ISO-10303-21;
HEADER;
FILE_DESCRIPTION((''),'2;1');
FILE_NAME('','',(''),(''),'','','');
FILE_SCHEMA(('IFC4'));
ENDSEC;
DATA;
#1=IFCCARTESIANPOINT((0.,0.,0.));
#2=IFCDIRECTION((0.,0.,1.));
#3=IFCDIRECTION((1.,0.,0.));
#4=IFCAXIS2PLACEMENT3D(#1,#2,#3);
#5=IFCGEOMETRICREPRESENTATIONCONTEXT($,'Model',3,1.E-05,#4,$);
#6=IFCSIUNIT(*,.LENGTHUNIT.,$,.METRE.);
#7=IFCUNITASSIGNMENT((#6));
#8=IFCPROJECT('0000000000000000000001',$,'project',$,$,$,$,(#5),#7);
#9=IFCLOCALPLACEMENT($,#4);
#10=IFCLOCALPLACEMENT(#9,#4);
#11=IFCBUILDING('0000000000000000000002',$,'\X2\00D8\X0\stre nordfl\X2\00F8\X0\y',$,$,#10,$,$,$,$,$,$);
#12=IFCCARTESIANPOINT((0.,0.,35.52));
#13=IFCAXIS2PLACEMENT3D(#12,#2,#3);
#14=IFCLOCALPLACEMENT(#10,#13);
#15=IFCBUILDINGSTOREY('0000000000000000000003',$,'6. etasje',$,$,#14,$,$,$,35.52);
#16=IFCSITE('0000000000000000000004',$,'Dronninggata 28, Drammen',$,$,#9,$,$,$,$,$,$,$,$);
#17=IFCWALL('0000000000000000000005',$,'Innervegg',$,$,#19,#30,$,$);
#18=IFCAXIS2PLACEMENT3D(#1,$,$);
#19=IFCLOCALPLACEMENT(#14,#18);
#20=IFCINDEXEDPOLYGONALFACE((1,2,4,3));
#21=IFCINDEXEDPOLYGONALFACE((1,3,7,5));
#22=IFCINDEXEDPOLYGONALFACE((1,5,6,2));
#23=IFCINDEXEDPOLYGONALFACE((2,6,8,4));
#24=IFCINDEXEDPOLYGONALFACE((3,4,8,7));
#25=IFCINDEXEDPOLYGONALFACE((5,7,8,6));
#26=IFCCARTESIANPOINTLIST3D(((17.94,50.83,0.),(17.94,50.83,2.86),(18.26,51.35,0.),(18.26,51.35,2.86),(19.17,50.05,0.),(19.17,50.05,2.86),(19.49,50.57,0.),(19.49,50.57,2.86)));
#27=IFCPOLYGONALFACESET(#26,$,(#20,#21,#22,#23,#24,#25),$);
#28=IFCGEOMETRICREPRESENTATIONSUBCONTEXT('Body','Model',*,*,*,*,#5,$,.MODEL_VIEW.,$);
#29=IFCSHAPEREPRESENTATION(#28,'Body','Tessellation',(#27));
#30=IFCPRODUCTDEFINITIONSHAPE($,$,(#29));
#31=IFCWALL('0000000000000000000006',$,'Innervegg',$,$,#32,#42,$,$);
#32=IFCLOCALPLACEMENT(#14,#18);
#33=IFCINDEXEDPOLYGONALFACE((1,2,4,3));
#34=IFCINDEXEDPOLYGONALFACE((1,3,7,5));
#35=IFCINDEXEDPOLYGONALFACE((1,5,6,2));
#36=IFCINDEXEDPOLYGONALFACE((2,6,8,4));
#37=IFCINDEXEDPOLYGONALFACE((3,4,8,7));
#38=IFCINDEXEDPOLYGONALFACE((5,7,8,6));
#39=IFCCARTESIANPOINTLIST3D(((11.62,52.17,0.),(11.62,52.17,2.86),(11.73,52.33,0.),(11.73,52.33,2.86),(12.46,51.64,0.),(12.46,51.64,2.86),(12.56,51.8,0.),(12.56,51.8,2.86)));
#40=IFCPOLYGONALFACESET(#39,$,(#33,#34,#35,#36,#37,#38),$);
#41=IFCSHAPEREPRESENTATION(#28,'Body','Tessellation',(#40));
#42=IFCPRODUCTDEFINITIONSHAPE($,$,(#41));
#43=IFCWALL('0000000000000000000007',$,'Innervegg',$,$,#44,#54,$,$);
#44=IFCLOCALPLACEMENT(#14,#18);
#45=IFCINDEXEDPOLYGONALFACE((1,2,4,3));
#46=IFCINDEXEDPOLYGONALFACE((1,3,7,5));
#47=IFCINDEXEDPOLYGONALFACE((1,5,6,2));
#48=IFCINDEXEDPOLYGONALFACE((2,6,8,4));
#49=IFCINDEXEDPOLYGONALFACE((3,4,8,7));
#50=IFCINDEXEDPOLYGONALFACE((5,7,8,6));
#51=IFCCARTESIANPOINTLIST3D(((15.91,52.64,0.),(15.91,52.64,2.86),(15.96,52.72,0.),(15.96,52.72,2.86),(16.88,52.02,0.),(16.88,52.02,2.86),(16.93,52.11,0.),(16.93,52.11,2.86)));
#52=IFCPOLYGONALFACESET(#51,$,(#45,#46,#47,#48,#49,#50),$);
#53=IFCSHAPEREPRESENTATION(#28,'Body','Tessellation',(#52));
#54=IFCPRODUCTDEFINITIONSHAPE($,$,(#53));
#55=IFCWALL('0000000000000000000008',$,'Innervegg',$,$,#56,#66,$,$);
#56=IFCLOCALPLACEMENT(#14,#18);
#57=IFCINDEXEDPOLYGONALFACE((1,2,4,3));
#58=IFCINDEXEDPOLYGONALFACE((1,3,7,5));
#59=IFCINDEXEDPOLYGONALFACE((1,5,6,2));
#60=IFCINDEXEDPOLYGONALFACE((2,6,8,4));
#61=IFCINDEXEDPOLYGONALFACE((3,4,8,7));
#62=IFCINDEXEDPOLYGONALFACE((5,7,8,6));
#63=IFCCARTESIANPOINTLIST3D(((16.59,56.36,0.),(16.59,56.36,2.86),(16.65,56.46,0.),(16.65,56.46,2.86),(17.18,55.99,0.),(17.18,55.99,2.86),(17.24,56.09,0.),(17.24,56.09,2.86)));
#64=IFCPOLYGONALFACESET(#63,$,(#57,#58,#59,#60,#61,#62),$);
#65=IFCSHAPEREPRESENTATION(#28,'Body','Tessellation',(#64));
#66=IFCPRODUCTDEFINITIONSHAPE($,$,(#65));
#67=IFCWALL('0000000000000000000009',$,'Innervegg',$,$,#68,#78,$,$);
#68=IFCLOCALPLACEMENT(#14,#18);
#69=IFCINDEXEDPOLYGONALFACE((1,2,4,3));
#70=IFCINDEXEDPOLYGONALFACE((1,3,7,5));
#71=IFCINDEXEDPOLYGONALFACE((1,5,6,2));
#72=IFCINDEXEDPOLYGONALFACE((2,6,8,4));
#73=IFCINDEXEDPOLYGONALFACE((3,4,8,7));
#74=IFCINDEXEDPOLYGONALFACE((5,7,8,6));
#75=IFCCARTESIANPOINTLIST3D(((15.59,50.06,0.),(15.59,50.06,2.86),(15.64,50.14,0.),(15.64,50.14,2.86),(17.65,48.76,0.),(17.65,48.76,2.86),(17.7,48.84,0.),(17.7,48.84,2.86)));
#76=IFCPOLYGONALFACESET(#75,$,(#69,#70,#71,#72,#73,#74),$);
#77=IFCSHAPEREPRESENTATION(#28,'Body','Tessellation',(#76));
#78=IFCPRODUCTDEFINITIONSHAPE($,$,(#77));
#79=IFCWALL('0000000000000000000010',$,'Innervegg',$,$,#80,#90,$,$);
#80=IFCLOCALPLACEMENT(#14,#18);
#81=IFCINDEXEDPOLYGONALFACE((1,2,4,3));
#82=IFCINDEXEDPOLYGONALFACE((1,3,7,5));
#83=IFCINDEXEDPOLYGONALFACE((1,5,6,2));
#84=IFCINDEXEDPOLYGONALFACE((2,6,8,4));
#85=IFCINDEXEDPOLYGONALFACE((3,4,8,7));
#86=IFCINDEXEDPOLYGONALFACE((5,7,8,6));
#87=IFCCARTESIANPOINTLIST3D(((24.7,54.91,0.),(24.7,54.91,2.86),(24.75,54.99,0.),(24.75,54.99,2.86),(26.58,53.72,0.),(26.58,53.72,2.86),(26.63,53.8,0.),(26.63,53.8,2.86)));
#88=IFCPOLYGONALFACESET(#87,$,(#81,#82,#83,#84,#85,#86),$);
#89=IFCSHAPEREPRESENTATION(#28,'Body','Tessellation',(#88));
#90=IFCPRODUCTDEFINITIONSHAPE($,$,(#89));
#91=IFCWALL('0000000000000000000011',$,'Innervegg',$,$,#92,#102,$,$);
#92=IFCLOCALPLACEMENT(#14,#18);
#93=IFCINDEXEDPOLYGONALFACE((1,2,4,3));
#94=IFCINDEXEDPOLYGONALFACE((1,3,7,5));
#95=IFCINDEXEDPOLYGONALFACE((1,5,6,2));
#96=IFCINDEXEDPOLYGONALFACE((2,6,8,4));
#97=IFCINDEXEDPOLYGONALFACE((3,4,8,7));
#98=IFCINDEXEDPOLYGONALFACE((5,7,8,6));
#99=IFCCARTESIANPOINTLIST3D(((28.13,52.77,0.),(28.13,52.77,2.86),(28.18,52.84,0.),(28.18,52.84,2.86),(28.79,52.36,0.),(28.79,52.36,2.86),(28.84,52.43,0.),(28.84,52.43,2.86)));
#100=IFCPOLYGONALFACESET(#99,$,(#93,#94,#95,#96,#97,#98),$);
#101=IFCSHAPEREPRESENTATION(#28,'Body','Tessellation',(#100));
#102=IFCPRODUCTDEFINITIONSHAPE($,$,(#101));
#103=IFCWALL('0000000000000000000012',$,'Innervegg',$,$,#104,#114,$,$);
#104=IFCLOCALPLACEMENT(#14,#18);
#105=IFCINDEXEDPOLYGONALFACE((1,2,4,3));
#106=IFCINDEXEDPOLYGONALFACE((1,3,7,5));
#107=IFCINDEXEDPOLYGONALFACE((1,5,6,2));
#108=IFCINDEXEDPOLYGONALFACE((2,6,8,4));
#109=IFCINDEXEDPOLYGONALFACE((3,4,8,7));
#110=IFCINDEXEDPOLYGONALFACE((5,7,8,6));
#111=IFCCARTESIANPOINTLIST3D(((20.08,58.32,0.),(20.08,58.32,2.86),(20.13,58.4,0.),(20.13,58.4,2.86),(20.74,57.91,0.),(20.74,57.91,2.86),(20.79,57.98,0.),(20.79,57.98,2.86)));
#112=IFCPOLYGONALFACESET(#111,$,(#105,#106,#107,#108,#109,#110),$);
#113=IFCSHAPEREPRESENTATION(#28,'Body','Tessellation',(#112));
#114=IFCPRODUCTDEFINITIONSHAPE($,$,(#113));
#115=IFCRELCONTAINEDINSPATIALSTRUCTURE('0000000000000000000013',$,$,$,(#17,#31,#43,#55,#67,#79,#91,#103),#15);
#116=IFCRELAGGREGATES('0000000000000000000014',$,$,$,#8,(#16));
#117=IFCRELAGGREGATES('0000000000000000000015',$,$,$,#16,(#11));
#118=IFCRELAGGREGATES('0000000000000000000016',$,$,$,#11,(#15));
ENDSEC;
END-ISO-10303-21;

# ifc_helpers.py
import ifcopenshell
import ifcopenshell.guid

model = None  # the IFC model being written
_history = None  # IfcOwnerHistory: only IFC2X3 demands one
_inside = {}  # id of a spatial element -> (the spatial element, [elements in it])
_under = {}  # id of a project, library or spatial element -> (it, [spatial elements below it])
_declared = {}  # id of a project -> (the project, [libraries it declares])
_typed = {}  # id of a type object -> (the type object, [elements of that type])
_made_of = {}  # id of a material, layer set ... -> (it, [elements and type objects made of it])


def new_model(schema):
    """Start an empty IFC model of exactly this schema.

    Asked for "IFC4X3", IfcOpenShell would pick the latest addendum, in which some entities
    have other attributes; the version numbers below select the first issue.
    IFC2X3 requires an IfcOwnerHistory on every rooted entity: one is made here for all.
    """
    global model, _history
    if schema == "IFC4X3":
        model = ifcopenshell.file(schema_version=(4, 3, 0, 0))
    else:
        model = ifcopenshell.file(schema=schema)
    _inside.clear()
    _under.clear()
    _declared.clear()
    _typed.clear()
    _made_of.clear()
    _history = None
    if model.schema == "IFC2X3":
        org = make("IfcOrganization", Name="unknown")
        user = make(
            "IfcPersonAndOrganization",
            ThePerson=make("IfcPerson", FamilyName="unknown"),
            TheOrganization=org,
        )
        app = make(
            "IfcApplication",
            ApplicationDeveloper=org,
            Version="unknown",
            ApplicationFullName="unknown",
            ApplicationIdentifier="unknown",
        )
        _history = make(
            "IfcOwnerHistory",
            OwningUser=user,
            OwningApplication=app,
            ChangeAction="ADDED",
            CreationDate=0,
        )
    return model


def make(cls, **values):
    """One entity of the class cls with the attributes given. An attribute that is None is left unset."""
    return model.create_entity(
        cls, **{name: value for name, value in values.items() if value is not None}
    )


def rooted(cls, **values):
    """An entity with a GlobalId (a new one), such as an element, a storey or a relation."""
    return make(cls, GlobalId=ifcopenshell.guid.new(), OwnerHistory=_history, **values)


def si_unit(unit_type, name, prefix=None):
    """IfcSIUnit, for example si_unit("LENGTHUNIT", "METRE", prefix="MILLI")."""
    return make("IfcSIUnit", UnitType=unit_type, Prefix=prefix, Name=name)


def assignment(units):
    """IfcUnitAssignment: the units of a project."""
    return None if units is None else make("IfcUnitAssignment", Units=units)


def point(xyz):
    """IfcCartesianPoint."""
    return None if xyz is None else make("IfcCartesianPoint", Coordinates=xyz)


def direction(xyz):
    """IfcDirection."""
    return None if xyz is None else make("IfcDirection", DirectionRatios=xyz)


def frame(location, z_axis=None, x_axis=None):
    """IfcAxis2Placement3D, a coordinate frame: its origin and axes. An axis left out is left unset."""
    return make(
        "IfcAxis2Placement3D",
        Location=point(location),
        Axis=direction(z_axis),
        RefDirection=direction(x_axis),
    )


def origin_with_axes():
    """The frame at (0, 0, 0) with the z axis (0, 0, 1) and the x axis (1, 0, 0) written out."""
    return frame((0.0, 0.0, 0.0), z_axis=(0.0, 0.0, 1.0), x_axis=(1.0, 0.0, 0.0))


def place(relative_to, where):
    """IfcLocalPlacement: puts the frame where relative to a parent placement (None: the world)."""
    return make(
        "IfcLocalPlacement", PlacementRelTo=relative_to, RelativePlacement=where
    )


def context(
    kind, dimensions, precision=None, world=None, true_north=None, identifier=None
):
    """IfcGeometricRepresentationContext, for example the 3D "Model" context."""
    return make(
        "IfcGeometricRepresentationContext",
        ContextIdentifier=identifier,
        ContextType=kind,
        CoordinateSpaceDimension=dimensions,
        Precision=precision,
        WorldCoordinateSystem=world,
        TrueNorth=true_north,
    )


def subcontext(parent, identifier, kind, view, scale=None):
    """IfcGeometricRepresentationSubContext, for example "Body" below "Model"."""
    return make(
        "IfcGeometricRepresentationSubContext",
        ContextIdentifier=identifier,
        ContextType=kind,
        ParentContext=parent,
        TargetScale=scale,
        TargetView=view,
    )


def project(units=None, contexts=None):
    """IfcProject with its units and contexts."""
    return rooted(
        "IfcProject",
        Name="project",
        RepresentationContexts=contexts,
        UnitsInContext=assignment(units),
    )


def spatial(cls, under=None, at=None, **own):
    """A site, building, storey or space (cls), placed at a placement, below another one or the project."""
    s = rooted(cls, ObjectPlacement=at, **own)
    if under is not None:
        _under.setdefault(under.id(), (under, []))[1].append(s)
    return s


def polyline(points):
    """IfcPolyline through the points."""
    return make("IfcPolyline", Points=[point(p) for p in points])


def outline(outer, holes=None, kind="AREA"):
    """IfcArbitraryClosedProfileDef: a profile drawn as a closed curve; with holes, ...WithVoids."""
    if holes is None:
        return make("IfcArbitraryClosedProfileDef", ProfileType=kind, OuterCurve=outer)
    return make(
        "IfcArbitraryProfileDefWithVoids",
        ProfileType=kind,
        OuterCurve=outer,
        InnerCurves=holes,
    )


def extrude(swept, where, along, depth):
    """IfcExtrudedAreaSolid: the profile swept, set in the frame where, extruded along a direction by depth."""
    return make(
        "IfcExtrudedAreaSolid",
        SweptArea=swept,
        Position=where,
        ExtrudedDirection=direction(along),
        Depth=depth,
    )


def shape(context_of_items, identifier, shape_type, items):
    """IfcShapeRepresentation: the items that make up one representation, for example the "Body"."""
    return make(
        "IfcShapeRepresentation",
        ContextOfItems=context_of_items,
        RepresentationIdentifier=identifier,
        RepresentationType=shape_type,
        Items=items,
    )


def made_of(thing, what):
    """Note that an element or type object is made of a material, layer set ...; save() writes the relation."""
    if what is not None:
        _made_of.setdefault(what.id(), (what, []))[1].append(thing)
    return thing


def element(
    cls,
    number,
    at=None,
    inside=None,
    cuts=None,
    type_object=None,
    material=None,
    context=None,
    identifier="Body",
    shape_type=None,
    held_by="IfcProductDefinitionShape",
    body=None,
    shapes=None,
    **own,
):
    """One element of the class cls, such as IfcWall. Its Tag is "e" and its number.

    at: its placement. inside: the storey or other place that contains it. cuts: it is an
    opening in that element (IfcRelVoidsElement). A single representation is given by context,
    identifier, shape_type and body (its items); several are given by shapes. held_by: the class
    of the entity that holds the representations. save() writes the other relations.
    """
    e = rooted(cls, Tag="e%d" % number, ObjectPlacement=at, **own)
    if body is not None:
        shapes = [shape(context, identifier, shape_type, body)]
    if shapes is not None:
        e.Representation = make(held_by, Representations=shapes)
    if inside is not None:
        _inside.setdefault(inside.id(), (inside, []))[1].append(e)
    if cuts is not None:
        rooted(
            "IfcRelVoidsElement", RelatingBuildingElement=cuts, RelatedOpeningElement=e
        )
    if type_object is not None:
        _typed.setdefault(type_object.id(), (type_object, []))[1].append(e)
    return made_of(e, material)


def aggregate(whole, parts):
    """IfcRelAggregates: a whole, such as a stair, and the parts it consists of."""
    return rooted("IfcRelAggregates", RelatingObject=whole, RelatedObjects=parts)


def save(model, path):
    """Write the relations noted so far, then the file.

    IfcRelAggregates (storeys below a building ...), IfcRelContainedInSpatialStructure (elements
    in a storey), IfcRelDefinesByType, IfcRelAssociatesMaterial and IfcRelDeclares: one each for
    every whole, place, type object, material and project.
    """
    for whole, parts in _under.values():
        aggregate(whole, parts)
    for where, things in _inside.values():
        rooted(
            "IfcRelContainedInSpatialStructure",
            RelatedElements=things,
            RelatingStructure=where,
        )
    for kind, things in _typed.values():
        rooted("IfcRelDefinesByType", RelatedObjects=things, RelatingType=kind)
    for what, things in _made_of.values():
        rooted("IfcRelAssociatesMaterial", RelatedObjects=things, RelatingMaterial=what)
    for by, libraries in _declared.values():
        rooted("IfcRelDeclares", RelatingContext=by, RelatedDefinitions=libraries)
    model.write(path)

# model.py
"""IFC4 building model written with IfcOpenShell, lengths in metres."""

from ifc_helpers import new_model, si_unit, frame, origin_with_axes, place, context, subcontext, project, spatial, polyline, outline, extrude, element, save


model = new_model("IFC4")

# Units and contexts
model_context = context("Model", 3, precision=1e-05, world=origin_with_axes())
body_context = subcontext(model_context, "Body", "Model", "MODEL_VIEW")
ifc_project = project(units=[si_unit("LENGTHUNIT", "METRE")], contexts=[model_context])

# Site, building, storey
site_placement = place(None, origin_with_axes())
site = spatial("IfcSite", under=ifc_project, at=site_placement, Name="Dronninggata 28, Drammen")
building_placement = place(site_placement, origin_with_axes())
building = spatial("IfcBuilding", under=site, at=building_placement, Name="Østre nordfløy")
storey_placement = place(building_placement, frame((0.0, 0.0, 35.52), z_axis=(0.0, 0.0, 1.0), x_axis=(1.0, 0.0, 0.0)))
storey = spatial("IfcBuildingStorey", under=building, at=storey_placement, Name="6. etasje", Elevation=35.52)

# Walls
wall_1_placement = place(storey_placement, frame((0.0, 0.0, -35.52), z_axis=(0.0, 0.0, 1.0), x_axis=(1.0, 0.0, 0.0)))
element("IfcWall", 1, at=wall_1_placement, inside=storey, Name="Innervegg", context=body_context, shape_type="SweptSolid", body=[
    extrude(outline(polyline([(19.49, 50.57), (19.17, 50.05), (17.94, 50.83), (18.26, 51.35), (19.49, 50.57)])), frame((0.0, 0.0, 35.52)), (0.0, 0.0, 1.0), 2.86),
])
wall_2_placement = place(storey_placement, frame((0.0, 0.0, -35.52), z_axis=(0.0, 0.0, 1.0), x_axis=(1.0, 0.0, 0.0)))
element("IfcWall", 2, at=wall_2_placement, inside=storey, Name="Innervegg", context=body_context, shape_type="SweptSolid", body=[
    extrude(outline(polyline([(12.56, 51.8), (12.46, 51.64), (11.62, 52.17), (11.73, 52.33), (12.56, 51.8)])), frame((0.0, 0.0, 35.52)), (0.0, 0.0, 1.0), 2.86),
])
wall_3_placement = place(storey_placement, frame((0.0, 0.0, -35.52), z_axis=(0.0, 0.0, 1.0), x_axis=(1.0, 0.0, 0.0)))
element("IfcWall", 3, at=wall_3_placement, inside=storey, Name="Innervegg", context=body_context, shape_type="SweptSolid", body=[
    extrude(outline(polyline([(16.93, 52.11), (16.88, 52.02), (15.91, 52.64), (15.96, 52.72), (16.93, 52.11)])), frame((0.0, 0.0, 35.52)), (0.0, 0.0, 1.0), 2.86),
])
wall_4_placement = place(storey_placement, frame((0.0, 0.0, -35.52), z_axis=(0.0, 0.0, 1.0), x_axis=(1.0, 0.0, 0.0)))
element("IfcWall", 4, at=wall_4_placement, inside=storey, Name="Innervegg", context=body_context, shape_type="SweptSolid", body=[
    extrude(outline(polyline([(17.24, 56.09), (17.18, 55.99), (16.59, 56.36), (16.65, 56.46), (17.24, 56.09)])), frame((0.0, 0.0, 35.52)), (0.0, 0.0, 1.0), 2.86),
])
wall_5_placement = place(storey_placement, frame((0.0, 0.0, -35.52), z_axis=(0.0, 0.0, 1.0), x_axis=(1.0, 0.0, 0.0)))
element("IfcWall", 5, at=wall_5_placement, inside=storey, Name="Innervegg", context=body_context, shape_type="SweptSolid", body=[
    extrude(outline(polyline([(17.7, 48.84), (17.65, 48.76), (15.59, 50.06), (15.64, 50.14), (17.7, 48.84)])), frame((0.0, 0.0, 35.52)), (0.0, 0.0, 1.0), 2.86),
])
wall_6_placement = place(storey_placement, frame((0.0, 0.0, -35.52), z_axis=(0.0, 0.0, 1.0), x_axis=(1.0, 0.0, 0.0)))
element("IfcWall", 6, at=wall_6_placement, inside=storey, Name="Innervegg", context=body_context, shape_type="SweptSolid", body=[
    extrude(outline(polyline([(26.63, 53.8), (26.58, 53.72), (24.7, 54.91), (24.75, 54.99), (26.63, 53.8)])), frame((0.0, 0.0, 35.52)), (0.0, 0.0, 1.0), 2.86),
])
wall_7_placement = place(storey_placement, frame((0.0, 0.0, -35.52), z_axis=(0.0, 0.0, 1.0), x_axis=(1.0, 0.0, 0.0)))
element("IfcWall", 7, at=wall_7_placement, inside=storey, Name="Innervegg", context=body_context, shape_type="SweptSolid", body=[
    extrude(outline(polyline([(28.84, 52.43), (28.79, 52.36), (28.13, 52.77), (28.18, 52.84), (28.84, 52.43)])), frame((0.0, 0.0, 35.52)), (0.0, 0.0, 1.0), 2.86),
])
wall_8_placement = place(storey_placement, frame((0.0, 0.0, -35.52), z_axis=(0.0, 0.0, 1.0), x_axis=(1.0, 0.0, 0.0)))
element("IfcWall", 8, at=wall_8_placement, inside=storey, Name="Innervegg", context=body_context, shape_type="SweptSolid", body=[
    extrude(outline(polyline([(20.79, 57.98), (20.74, 57.91), (20.08, 58.32), (20.13, 58.4), (20.79, 57.98)])), frame((0.0, 0.0, 35.52)), (0.0, 0.0, 1.0), 2.86),
])

save(model, "model.ifc")
